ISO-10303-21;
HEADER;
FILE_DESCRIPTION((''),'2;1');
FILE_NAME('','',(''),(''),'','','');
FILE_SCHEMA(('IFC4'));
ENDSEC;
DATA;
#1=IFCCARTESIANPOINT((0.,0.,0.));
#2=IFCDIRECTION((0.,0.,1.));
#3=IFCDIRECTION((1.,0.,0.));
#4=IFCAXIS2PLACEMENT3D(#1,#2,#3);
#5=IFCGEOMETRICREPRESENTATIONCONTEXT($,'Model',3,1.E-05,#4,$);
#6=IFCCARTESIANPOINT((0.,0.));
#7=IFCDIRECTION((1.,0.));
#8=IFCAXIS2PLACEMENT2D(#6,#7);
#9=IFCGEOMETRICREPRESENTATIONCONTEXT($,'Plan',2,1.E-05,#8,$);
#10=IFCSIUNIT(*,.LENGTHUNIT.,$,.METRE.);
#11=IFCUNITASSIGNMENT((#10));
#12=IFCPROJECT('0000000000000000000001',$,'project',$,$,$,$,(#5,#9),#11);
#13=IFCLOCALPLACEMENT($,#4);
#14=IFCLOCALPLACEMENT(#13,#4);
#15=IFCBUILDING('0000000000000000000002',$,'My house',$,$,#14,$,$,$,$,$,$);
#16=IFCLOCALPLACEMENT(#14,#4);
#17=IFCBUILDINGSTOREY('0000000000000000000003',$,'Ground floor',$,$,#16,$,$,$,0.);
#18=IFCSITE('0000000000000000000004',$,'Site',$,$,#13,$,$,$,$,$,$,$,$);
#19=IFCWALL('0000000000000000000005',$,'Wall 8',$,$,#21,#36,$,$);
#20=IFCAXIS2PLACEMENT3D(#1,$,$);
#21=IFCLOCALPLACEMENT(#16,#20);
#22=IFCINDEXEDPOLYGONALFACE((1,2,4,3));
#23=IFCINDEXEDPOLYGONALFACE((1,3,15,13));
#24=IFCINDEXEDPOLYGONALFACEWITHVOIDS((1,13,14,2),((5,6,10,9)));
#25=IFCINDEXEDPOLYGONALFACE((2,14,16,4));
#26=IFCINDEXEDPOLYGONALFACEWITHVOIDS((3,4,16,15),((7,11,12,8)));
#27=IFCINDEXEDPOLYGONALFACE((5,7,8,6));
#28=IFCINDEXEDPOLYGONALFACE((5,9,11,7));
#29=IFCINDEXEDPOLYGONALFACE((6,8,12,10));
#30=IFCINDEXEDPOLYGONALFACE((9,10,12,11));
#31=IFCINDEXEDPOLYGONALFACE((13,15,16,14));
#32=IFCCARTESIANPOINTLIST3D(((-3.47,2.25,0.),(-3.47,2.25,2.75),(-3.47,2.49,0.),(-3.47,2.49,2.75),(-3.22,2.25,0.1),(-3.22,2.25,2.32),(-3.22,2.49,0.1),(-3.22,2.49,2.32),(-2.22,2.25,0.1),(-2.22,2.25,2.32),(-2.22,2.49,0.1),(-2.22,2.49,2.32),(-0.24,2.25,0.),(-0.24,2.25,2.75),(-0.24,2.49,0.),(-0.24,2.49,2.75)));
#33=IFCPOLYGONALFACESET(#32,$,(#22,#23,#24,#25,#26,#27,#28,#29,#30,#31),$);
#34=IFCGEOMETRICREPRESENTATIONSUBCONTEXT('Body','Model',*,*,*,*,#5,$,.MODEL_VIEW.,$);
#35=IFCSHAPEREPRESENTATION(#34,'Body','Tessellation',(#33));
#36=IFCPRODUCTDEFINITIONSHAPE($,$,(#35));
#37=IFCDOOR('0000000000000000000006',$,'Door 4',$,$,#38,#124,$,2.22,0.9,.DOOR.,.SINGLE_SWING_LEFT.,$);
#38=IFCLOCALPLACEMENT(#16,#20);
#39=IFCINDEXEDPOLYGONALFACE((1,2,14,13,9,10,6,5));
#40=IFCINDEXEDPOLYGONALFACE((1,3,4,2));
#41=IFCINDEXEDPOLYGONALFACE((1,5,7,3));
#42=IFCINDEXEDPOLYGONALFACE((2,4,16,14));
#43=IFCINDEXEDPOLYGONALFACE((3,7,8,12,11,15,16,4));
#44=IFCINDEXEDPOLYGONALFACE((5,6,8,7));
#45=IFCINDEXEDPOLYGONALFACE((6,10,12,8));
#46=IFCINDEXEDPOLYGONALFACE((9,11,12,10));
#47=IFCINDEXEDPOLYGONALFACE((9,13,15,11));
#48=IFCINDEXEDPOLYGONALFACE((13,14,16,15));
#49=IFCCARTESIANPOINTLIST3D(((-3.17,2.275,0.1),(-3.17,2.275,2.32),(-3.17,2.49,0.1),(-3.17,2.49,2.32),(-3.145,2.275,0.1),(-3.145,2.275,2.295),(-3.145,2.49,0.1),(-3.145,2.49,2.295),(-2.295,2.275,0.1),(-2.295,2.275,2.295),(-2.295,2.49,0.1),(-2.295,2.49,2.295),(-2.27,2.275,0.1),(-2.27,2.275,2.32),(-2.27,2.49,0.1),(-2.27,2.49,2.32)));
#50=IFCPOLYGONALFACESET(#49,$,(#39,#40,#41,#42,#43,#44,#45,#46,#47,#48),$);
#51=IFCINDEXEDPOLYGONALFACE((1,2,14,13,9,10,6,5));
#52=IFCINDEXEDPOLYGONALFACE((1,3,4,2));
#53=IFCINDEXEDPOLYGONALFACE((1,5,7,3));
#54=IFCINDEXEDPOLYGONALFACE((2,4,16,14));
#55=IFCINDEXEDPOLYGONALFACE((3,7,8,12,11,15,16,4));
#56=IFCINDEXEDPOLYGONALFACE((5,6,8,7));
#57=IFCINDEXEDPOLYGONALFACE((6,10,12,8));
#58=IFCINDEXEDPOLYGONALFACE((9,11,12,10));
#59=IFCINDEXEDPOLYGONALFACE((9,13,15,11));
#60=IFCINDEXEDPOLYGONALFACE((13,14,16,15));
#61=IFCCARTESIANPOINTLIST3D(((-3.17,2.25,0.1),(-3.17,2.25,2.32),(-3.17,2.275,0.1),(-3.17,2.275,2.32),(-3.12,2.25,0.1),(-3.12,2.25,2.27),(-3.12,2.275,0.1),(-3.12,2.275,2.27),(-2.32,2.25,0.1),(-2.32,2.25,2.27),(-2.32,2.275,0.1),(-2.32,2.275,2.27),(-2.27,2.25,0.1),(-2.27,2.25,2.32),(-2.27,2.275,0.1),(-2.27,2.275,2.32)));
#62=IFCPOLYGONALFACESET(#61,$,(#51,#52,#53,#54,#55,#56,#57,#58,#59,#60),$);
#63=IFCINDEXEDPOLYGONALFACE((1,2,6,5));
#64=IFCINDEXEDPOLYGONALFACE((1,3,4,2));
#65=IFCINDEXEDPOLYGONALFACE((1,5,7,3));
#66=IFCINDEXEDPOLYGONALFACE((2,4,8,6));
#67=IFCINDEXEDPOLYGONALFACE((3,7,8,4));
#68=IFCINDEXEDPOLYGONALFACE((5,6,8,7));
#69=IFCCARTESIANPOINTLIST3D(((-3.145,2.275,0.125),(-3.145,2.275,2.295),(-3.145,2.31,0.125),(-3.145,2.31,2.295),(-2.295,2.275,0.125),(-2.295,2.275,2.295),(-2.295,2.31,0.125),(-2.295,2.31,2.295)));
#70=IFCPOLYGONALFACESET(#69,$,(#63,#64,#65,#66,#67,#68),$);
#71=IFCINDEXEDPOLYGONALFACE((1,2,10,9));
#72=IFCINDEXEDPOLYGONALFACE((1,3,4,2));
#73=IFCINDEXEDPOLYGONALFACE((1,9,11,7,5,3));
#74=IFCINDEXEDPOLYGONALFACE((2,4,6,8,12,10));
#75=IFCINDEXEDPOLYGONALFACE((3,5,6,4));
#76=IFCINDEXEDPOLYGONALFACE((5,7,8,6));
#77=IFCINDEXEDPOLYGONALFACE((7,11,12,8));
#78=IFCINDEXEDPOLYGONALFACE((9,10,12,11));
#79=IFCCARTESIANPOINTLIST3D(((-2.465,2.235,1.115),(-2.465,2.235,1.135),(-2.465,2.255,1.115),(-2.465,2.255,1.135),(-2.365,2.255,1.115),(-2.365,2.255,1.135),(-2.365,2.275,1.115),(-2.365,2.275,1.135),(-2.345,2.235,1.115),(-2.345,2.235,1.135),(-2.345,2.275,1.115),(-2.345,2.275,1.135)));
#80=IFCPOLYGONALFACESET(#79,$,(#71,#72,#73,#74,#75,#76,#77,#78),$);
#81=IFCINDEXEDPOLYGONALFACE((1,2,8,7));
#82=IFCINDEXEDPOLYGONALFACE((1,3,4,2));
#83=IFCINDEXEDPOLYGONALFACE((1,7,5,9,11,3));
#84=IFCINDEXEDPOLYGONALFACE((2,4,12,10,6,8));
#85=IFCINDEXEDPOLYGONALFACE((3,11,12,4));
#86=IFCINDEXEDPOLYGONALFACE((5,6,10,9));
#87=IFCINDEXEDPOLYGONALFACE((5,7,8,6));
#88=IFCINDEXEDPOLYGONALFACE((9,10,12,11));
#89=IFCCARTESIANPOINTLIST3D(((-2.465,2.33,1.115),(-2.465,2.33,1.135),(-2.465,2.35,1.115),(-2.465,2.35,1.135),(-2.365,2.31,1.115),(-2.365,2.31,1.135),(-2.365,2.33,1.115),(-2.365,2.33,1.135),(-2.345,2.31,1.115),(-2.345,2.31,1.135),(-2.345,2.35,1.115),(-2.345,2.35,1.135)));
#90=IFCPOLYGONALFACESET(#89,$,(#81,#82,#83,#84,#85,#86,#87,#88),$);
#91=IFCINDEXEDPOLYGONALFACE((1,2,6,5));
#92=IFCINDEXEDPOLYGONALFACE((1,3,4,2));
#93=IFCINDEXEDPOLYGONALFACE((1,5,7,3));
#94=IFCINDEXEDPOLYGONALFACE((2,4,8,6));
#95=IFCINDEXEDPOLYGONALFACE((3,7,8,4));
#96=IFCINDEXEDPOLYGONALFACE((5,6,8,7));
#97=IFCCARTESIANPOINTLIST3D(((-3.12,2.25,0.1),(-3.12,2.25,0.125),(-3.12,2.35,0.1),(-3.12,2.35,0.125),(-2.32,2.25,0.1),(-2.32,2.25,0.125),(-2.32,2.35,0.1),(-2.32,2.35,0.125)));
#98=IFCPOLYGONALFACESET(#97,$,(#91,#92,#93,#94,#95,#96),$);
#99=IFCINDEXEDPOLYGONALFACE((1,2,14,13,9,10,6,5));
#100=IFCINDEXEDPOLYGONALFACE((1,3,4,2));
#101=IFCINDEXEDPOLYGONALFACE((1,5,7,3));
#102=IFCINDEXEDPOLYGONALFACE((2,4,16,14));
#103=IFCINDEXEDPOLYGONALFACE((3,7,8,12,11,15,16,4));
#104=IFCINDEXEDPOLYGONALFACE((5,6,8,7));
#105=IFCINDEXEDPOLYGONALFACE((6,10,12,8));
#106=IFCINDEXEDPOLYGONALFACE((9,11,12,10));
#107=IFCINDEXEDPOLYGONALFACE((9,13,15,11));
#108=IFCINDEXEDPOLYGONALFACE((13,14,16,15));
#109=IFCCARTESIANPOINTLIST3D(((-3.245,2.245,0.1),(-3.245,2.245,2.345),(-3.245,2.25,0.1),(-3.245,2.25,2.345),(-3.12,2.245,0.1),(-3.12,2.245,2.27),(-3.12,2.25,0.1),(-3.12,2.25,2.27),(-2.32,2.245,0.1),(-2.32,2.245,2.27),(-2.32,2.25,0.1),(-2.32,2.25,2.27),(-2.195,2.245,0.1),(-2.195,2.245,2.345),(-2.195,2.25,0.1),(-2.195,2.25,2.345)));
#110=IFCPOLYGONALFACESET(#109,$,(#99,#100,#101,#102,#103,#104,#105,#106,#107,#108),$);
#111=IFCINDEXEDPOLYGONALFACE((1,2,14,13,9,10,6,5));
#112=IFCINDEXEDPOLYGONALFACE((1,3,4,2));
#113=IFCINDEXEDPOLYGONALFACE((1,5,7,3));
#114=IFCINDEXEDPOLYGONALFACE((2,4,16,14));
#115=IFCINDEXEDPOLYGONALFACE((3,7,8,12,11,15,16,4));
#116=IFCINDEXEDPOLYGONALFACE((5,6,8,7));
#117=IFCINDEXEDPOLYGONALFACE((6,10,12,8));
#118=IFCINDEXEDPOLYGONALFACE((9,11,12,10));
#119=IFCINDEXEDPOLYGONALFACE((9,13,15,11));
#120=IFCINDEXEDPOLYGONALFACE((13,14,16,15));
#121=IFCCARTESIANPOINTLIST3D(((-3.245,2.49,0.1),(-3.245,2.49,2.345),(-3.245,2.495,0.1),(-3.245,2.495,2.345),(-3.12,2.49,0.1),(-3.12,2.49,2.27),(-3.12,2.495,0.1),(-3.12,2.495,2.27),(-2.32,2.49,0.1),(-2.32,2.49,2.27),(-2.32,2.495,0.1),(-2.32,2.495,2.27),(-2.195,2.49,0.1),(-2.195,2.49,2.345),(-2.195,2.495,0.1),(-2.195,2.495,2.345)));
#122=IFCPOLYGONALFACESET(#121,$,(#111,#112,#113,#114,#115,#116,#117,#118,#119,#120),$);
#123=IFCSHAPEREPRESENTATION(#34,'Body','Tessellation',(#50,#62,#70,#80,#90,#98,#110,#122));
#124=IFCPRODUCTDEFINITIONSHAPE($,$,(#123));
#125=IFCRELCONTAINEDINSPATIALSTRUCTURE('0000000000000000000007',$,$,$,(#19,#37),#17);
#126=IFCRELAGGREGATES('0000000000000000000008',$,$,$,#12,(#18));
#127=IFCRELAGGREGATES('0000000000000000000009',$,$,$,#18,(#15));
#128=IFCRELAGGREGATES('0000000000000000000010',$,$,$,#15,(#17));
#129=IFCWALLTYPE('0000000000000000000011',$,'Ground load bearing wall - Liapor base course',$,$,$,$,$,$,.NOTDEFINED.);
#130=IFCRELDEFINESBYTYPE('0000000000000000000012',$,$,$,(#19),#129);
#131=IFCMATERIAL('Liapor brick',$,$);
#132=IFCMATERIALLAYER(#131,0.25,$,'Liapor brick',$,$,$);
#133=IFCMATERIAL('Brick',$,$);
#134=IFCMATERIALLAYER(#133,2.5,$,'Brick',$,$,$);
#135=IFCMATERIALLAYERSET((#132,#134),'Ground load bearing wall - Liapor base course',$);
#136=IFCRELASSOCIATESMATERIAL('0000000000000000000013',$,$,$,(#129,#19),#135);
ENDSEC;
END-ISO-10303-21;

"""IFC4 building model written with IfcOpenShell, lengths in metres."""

from ifc_helpers import new_model, entity, si_unit, frame, origin_with_axes, origin_2d_with_axis, place, context, subcontext, project, spatial, line, indexed_curve, outline, extrude, shape, source, transform, mapped, material, layer, layer_set, layer_usage, type_object, element, fill, save


model = new_model("IFC4")

# Units and contexts
model_context = context("Model", 3, precision=1e-05, world=origin_with_axes())
plan_context = context("Plan", 2, precision=1e-05, world=origin_2d_with_axis())
body_context_1 = subcontext(model_context, "Body", "Model", "MODEL_VIEW")
body_context_2 = subcontext(plan_context, "Body", "Plan", "PLAN_VIEW")
ifc_project = project(units=[si_unit("LENGTHUNIT", "METRE")], contexts=[model_context, plan_context])

# Site, building, storey
site_placement = place(None, origin_with_axes())
site = spatial("IfcSite", under=ifc_project, at=site_placement, Name="Site")
building_placement = place(site_placement, origin_with_axes())
building = spatial("IfcBuilding", under=site, at=building_placement, Name="My house")
storey_placement = place(building_placement, origin_with_axes())
storey = spatial("IfcBuildingStorey", under=building, at=storey_placement, Name="Ground floor", Elevation=0.0)

# Shared definitions
ifc_material_1 = material(Name="Liapor brick")
ifc_layer_1 = layer(ifc_material_1, 0.25, Name="Liapor brick")
ifc_material_2 = material(Name="Brick")
ifc_layer_2 = layer(ifc_material_2, 2.5, Name="Brick")
ifc_layer_set_1 = layer_set([ifc_layer_1, ifc_layer_2], Name="Ground load bearing wall - Liapor base course")
wall_type_1 = type_object("IfcWallType", Name="Ground load bearing wall - Liapor base course", PredefinedType="NOTDEFINED", material=ifc_layer_set_1)

# Wall, opening, door
ifc_layer_usage_1 = layer_usage(ifc_layer_set_1, "AXIS3", "POSITIVE", 0.0)
shared_shape_1 = source(origin_with_axes(), body_context_1, "Body", "SweptSolid", [
    extrude(outline(indexed_curve([(0.0, 0.0), (0.0, 0.24), (3.23, 0.24), (3.23, 0.0), (0.0, 0.0)], self_intersect=False)), origin_with_axes(), (0.0, 0.0, 1.0), 2.75),
])
wall_1_placement = place(storey_placement, frame((-0.24, 2.25, 0.0), z_axis=(0.0, 0.0, 1.0), x_axis=(1.0, 0.0, 0.0)))
wall_1 = element("IfcWall", 1, at=wall_1_placement, inside=storey, type_object=wall_type_1, material=ifc_layer_usage_1, Name="Wall 8", context=body_context_1, shape_type="MappedRepresentation", body=[
    mapped(shared_shape_1, transform((0.0, 0.0, 0.0), x_axis=(-1.0, 0.0, 0.0), y_axis=(0.0, 1.0, 0.0), z_axis=(0.0, 0.0, 1.0), scale=1.0)),
])
shared_shape_2 = source(origin_with_axes(), body_context_1, "Body", "SweptSolid", [
    extrude(outline(indexed_curve([(0.0, 0.0), (0.0, 0.34), (1.0, 0.34), (1.0, 0.0), (0.0, 0.0)], self_intersect=False)), frame((0.0, -0.05, 0.0), z_axis=(0.0, 0.0, 1.0), x_axis=(1.0, 0.0, 0.0)), (0.0, 0.0, 1.0), 2.22),
])
opening_1_placement = place(wall_1_placement, frame((-1.98, 0.0, 0.1), z_axis=(0.0, 0.0, 1.0), x_axis=(1.0, 0.0, 0.0)))
opening_1 = element("IfcOpeningElement", 2, at=opening_1_placement, cuts=wall_1, PredefinedType="OPENING", context=body_context_1, shape_type="MappedRepresentation", body=[
    mapped(shared_shape_2, transform((0.0, 0.0, 0.0), x_axis=(-1.0, 0.0, 0.0), y_axis=(0.0, 1.0, 0.0), z_axis=(0.0, 0.0, 1.0), scale=1.0)),
])
shared_indexed_poly_curve_1 = entity("IfcIndexedPolyCurve", entity("IfcCartesianPointList2D", [[-0.075, 0.0], [-0.075, 2.245], [0.975, 2.245], [0.975, 0.0], [0.85, 0.0], [0.85, 2.17], [0.05, 2.17], [0.05, 0.0]]), [entity("IfcLineIndex", [1, 2, 3, 4, 5, 6, 7, 8, 1])])
shared_shape_3 = source(origin_with_axes(), body_context_1, "Body", "SweptSolid", [
    extrude(outline(indexed_curve([(0.0, 0.0), (0.0, 2.22), (0.9, 2.22), (0.9, 0.0), (0.875, 0.0), (0.875, 2.195), (0.025, 2.195), (0.025, 0.0)], segments=[line(1, 2, 3, 4, 5, 6, 7, 8, 1)])), frame((0.0, 0.025, 0.0), z_axis=(0.0, -1.0, 0.0), x_axis=(1.0, 0.0, 0.0)), (0.0, 0.0, -1.0), 0.215),
    extrude(outline(indexed_curve([(0.0, 0.0), (0.0, 2.22), (0.9, 2.22), (0.9, 0.0), (0.85, 0.0), (0.85, 2.17), (0.05, 2.17), (0.05, 0.0)], segments=[line(1, 2, 3, 4, 5, 6, 7, 8, 1)])), frame((0.0, 0.0, 0.0), z_axis=(0.0, -1.0, 0.0), x_axis=(1.0, 0.0, 0.0)), (0.0, 0.0, -1.0), 0.025),
    extrude(outline(indexed_curve([(0.0, 0.0), (0.85, 0.0), (0.85, 0.035), (0.0, 0.035)], segments=[line(1, 2, 3, 4, 1)])), frame((0.025, 0.025, 0.025), z_axis=(0.0, 0.0, 1.0), x_axis=(1.0, 0.0, 0.0)), (0.0, 0.0, 1.0), 2.17),
    extrude(outline(indexed_curve([(0.0, 0.0), (0.0, -0.04), (0.12, -0.04), (0.12, -0.02), (0.02, -0.02), (0.02, 0.0)], segments=[line(1, 2, 3, 4, 5, 6, 1)])), frame((0.075, 0.025, 1.015), z_axis=(0.0, 0.0, 1.0), x_axis=(1.0, 0.0, 0.0)), (0.0, 0.0, 1.0), 0.02),
    extrude(outline(indexed_curve([(0.0, 0.0), (0.0, 0.04), (0.12, 0.04), (0.12, 0.02), (0.02, 0.02), (0.02, 0.0)], segments=[line(1, 2, 3, 4, 5, 6, 1)])), frame((0.075, 0.06, 1.015), z_axis=(0.0, 0.0, 1.0), x_axis=(1.0, 0.0, 0.0)), (0.0, 0.0, 1.0), 0.02),
    extrude(outline(indexed_curve([(0.0, 0.0), (0.8, 0.0), (0.8, 0.1), (0.0, 0.1)], segments=[line(1, 2, 3, 4, 1)])), frame((0.05, 0.0, 0.0), z_axis=(0.0, 0.0, 1.0), x_axis=(1.0, 0.0, 0.0)), (0.0, 0.0, 1.0), 0.025),
    entity("IfcExtrudedAreaSolid", entity("IfcArbitraryClosedProfileDef", "AREA", None, shared_indexed_poly_curve_1), entity("IfcAxis2Placement3D", entity("IfcCartesianPoint", [0.0, -0.005, 0.0]), entity("IfcDirection", [0.0, -1.0, 0.0]), entity("IfcDirection", [1.0, 0.0, 0.0])), entity("IfcDirection", [0.0, 0.0, -1.0]), 0.005),
    entity("IfcExtrudedAreaSolid", entity("IfcArbitraryClosedProfileDef", "AREA", None, shared_indexed_poly_curve_1), entity("IfcAxis2Placement3D", entity("IfcCartesianPoint", [0.0, 0.24, 0.0]), entity("IfcDirection", [0.0, -1.0, 0.0]), entity("IfcDirection", [1.0, 0.0, 0.0])), entity("IfcDirection", [0.0, 0.0, -1.0]), 0.005),
])
shared_shape_4 = source(origin_with_axes(), body_context_2, "Body", "Curve2D", [
    entity("IfcIndexedPolyCurve", entity("IfcCartesianPointList2D", [[0.0, 0.0], [0.0, 0.24], [0.025, 0.24], [0.025, 0.025], [0.05, 0.025], [0.05, 0.0]]), [entity("IfcLineIndex", [1, 2, 3, 4, 5, 6, 1])]),
    entity("IfcIndexedPolyCurve", entity("IfcCartesianPointList2D", [[0.9, 0.0], [0.9, 0.24], [0.875, 0.24], [0.875, 0.025], [0.85, 0.025], [0.85, 0.0]]), [entity("IfcLineIndex", [1, 2, 3, 4, 5, 6, 1])]),
    entity("IfcTrimmedCurve", entity("IfcEllipse", entity("IfcAxis2Placement2D", entity("IfcCartesianPoint", [0.84, 0.24]), entity("IfcDirection", [1.0, 0.0])), 0.815, 0.85), [entity("IfcCartesianPoint", [0.84, 1.09])], [entity("IfcCartesianPoint", [0.025, 0.24])], True, "CARTESIAN"),
    entity("IfcIndexedPolyCurve", entity("IfcCartesianPointList2D", [[0.875, 0.24], [0.84, 0.24], [0.84, 1.09], [0.875, 1.09]]), [entity("IfcLineIndex", [1, 2, 3, 4, 1])]),
])
door_1_placement = place(opening_1_placement, frame((-0.05, 0.0, 0.0), z_axis=(0.0, 0.0, 1.0), x_axis=(1.0, 0.0, 0.0)))
door_1 = element("IfcDoor", 3, at=door_1_placement, inside=storey, Name="Door 4", OperationType="SINGLE_SWING_LEFT", OverallHeight=2.22, OverallWidth=0.9, PredefinedType="DOOR", shapes=[
    shape(body_context_1, "Body", "MappedRepresentation", [mapped(shared_shape_3, transform((0.0, 0.0, 0.0), x_axis=(-1.0, 0.0, 0.0), y_axis=(0.0, 1.0, 0.0), z_axis=(0.0, 0.0, 1.0), scale=1.0))]),
    shape(body_context_2, "Body", "MappedRepresentation", [mapped(shared_shape_4, transform((0.0, 0.0, 0.0), x_axis=(-1.0, 0.0, 0.0), y_axis=(0.0, 1.0, 0.0), z_axis=(0.0, 0.0, 1.0), scale=1.0))]),
])
fill(opening_1, door_1)

save(model, "model.ifc")
